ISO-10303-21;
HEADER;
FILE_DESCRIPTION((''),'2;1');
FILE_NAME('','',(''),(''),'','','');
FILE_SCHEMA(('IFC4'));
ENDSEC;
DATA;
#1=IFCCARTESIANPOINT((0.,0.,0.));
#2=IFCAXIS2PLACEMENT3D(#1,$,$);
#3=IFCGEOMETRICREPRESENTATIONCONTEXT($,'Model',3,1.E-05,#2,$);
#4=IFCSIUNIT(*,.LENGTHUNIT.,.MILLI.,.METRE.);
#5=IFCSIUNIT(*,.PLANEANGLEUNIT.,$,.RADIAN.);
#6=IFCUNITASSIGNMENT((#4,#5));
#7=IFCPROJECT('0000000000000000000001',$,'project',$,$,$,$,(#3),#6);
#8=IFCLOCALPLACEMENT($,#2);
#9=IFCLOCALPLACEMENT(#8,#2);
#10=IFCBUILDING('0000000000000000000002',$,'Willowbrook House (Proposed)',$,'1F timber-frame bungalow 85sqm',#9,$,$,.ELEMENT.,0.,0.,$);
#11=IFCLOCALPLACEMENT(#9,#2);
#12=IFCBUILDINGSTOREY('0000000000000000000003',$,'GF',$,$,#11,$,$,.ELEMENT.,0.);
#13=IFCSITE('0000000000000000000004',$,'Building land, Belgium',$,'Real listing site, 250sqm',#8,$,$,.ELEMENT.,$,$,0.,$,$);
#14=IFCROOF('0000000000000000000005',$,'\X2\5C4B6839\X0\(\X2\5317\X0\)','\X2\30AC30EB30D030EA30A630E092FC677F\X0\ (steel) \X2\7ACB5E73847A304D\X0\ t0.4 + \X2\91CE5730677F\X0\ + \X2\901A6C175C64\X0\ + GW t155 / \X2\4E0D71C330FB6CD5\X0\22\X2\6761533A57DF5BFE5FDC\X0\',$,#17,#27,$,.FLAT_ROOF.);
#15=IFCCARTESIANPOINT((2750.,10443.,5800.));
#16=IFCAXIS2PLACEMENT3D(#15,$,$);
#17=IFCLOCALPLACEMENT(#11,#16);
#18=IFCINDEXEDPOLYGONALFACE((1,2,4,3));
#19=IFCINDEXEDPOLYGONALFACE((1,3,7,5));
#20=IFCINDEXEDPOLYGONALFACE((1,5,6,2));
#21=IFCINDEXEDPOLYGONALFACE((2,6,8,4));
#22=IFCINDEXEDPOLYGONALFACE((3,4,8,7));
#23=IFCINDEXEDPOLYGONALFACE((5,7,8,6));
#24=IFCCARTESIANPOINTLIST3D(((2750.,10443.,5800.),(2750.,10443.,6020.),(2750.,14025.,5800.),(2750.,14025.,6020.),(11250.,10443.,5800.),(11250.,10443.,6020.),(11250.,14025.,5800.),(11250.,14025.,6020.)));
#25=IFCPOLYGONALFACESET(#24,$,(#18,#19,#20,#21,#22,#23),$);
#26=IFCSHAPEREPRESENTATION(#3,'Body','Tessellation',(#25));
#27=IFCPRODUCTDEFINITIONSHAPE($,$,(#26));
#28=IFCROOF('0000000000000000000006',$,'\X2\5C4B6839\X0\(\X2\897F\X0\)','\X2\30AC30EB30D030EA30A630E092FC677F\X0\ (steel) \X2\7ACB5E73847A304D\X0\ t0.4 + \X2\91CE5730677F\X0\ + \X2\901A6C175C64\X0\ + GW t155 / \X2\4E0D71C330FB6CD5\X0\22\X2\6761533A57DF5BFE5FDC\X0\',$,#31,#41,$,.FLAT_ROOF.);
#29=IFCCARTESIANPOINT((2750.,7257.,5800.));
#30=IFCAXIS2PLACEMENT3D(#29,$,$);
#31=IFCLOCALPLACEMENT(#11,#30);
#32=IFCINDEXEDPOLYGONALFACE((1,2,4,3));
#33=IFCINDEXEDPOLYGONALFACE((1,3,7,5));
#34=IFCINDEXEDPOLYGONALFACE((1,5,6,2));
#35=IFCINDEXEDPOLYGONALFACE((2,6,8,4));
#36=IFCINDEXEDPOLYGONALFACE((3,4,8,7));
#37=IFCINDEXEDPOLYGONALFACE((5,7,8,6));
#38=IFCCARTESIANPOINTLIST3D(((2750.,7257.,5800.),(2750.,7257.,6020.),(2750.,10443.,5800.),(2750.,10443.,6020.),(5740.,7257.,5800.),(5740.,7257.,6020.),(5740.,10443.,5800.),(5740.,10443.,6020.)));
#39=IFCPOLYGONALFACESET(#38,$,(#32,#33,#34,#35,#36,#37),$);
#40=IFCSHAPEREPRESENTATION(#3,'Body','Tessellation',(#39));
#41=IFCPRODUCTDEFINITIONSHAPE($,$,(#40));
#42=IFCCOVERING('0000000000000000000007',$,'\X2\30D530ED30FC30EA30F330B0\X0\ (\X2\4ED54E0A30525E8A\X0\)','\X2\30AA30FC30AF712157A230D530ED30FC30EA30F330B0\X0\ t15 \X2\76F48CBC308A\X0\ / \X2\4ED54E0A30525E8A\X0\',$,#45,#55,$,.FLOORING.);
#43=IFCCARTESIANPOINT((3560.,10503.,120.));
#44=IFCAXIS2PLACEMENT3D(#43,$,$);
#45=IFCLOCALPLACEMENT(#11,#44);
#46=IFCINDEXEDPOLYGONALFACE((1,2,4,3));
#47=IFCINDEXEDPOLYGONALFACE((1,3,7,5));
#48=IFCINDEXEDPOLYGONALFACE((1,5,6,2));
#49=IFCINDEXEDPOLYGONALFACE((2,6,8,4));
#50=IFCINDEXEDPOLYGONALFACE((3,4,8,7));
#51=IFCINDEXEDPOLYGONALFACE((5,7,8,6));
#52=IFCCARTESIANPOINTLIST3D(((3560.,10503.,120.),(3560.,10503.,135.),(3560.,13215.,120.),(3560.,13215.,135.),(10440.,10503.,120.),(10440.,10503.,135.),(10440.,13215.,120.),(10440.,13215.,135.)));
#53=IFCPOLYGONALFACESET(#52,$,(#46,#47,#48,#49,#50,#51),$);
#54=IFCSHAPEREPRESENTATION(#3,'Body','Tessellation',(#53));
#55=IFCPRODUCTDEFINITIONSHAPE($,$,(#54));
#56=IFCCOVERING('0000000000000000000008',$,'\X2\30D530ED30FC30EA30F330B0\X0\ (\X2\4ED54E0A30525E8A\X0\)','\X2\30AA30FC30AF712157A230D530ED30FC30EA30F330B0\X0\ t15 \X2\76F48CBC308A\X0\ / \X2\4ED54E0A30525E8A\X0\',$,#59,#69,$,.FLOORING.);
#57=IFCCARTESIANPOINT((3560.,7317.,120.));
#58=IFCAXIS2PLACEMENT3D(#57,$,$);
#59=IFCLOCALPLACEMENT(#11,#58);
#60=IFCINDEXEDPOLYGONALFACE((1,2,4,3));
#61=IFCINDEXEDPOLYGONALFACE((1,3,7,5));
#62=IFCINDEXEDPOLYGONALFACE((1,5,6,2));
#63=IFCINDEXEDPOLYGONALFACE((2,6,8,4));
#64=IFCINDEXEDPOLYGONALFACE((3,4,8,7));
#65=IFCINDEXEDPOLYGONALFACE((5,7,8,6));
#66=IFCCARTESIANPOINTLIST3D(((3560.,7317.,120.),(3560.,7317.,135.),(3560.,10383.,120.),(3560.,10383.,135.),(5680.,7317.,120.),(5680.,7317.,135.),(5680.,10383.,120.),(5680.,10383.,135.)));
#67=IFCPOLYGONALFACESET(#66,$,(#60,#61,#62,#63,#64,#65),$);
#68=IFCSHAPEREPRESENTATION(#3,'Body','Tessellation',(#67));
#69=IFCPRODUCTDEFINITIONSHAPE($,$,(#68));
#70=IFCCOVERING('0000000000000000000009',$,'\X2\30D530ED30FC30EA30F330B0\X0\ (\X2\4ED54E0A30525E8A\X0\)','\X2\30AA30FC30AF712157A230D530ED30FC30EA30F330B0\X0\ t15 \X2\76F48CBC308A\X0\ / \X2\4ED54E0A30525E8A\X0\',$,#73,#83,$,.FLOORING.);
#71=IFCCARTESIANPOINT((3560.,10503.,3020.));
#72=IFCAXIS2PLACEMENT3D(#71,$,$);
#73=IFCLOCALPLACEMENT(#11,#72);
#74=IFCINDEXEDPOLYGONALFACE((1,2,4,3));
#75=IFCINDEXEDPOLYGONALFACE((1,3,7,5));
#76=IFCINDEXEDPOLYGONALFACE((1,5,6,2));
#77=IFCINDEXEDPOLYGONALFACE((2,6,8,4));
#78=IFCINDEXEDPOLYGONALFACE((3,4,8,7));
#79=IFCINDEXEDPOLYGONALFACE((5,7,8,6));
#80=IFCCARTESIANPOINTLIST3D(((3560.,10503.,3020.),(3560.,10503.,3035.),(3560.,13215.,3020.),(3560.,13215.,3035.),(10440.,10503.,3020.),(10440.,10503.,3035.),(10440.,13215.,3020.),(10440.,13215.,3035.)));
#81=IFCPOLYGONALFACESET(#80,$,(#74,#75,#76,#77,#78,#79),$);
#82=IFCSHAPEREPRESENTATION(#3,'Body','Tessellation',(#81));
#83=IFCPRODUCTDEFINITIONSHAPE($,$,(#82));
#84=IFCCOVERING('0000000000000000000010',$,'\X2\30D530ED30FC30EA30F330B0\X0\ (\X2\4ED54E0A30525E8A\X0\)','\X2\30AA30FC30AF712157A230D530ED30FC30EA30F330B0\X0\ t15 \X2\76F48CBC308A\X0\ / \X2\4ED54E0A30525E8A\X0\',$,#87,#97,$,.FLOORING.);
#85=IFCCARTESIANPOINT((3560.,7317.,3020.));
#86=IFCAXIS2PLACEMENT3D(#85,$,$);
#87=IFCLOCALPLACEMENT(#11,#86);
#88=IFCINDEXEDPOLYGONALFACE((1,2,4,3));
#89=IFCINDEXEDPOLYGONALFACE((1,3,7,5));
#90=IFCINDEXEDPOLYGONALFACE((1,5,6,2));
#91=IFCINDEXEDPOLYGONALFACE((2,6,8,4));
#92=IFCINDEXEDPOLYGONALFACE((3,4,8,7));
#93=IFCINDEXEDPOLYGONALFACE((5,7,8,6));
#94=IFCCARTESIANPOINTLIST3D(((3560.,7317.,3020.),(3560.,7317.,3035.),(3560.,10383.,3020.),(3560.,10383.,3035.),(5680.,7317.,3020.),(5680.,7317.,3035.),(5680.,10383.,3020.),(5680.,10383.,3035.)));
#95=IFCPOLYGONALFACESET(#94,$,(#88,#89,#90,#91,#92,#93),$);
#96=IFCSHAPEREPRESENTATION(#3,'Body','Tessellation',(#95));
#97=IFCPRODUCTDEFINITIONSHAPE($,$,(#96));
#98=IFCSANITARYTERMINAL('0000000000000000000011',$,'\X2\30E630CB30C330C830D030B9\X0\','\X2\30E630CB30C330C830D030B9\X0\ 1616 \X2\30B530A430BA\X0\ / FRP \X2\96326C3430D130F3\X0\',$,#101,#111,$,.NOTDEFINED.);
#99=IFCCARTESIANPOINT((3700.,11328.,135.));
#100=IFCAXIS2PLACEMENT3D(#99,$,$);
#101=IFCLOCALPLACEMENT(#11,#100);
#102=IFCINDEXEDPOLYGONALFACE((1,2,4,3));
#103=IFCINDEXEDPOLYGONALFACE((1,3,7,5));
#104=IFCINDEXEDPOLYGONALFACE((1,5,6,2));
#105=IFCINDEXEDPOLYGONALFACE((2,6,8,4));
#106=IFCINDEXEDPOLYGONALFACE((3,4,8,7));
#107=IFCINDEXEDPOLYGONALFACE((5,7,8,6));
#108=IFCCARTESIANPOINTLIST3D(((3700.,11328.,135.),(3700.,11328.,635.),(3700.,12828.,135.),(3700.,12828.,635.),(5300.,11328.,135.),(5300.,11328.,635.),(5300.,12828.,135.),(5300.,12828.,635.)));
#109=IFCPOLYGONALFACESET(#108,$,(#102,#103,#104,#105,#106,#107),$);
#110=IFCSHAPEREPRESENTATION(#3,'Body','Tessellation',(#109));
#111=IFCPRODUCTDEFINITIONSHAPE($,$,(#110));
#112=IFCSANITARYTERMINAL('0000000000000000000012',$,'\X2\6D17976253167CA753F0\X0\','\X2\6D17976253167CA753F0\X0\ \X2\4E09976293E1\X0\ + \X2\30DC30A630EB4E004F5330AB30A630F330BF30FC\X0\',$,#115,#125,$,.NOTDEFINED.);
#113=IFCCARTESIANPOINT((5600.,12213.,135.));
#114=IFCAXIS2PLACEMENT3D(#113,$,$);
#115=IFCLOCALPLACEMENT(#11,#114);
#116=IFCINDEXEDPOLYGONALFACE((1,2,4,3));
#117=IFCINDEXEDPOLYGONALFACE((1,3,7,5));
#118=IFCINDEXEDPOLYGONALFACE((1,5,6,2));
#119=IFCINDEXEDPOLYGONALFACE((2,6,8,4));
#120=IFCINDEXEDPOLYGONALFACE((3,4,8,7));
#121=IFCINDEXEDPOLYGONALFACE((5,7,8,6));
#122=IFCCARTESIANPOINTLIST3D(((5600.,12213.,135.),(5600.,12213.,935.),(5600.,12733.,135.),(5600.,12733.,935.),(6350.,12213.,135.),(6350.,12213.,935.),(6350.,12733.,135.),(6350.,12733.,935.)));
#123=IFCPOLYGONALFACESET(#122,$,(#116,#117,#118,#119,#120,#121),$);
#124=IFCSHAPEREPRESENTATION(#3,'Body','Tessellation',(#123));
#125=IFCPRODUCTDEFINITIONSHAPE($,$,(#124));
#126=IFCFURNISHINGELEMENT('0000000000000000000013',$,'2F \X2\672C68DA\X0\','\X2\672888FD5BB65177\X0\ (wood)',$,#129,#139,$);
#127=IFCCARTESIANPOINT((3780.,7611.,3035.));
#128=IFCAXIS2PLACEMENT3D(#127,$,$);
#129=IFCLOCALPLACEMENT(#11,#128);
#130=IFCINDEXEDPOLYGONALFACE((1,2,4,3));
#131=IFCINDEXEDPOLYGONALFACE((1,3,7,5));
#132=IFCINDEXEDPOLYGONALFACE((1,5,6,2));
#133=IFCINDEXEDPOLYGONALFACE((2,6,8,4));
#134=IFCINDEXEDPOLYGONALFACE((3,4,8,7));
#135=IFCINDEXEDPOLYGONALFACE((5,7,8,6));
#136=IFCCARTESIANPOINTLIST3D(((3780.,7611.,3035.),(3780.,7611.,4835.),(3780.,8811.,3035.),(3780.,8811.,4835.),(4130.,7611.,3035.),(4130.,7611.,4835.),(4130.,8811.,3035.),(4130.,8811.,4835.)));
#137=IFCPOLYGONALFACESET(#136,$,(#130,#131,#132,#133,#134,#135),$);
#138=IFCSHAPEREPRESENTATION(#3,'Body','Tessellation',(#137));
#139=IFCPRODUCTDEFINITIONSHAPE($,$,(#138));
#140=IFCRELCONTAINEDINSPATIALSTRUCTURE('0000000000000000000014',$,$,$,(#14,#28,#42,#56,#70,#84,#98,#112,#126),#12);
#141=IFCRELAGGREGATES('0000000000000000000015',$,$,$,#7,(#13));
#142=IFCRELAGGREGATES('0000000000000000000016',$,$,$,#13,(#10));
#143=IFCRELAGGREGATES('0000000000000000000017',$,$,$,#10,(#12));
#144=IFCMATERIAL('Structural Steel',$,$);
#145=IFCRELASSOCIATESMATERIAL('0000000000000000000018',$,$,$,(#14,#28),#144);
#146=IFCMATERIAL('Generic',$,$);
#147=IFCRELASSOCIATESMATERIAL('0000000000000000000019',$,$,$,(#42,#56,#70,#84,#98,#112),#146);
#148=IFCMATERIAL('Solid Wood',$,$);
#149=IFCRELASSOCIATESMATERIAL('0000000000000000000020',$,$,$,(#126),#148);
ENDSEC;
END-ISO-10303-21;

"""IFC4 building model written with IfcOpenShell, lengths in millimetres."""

from ifc_helpers import new_model, si_unit, frame, frame_2d, origin, place, context, project, spatial, rectangle, extrude, material, element, save


model = new_model("IFC4")

# Units and contexts
model_context = context("Model", 3, precision=1e-05, world=origin())
ifc_project = project(units=[si_unit("LENGTHUNIT", "METRE", prefix="MILLI"), si_unit("PLANEANGLEUNIT", "RADIAN")], contexts=[model_context])

# Site, building, storey
site_placement = place(None, origin())
site = spatial("IfcSite", under=ifc_project, at=site_placement, Name="Building land, Belgium", ObjectType="Real listing site, 250sqm", CompositionType="ELEMENT", RefElevation=0.0)
building_placement = place(site_placement, origin())
building = spatial("IfcBuilding", under=site, at=building_placement, Name="Willowbrook House (Proposed)", ObjectType="1F timber-frame bungalow 85sqm", CompositionType="ELEMENT", ElevationOfRefHeight=0.0, ElevationOfTerrain=0.0)
storey_placement = place(building_placement, origin())
storey = spatial("IfcBuildingStorey", under=building, at=storey_placement, Name="GF", CompositionType="ELEMENT", Elevation=0.0)

# Shared definitions
ifc_material_1 = material(Name="Solid Wood")

# Roofs
ifc_material_2 = material(Name="Structural Steel")
for number, where, name in (
    (1, (2750.0, 10443.0, 5800.0), "屋根(北)"),
):
    element("IfcRoof", number, at=place(storey_placement, frame(where)), inside=storey, material=ifc_material_2, Name=name, Description="ガルバリウム鋼板 (steel) 立平葺き t0.4 + 野地板 + 通気層 + GW t155 / 不燃・法22条区域対応", PredefinedType="FLAT_ROOF", context=model_context, shape_type="SweptSolid", body=[
        extrude(rectangle(XDim=8500.0, YDim=3582.0, at=frame_2d((4250.0, 1791.0))), frame((2750.0, 10443.0, 5800.0)), (0.0, 0.0, 1.0), 220.0),
    ])
roof_placement = place(storey_placement, frame((2750.0, 7257.0, 5800.0)))
element("IfcRoof", 2, at=roof_placement, inside=storey, material=ifc_material_2, Name="屋根(西)", Description="ガルバリウム鋼板 (steel) 立平葺き t0.4 + 野地板 + 通気層 + GW t155 / 不燃・法22条区域対応", PredefinedType="FLAT_ROOF", context=model_context, shape_type="SweptSolid", body=[
    extrude(rectangle(XDim=2990.0, YDim=3186.0, at=frame_2d((1495.0, 1593.0))), frame((2750.0, 7257.0, 5800.0)), (0.0, 0.0, 1.0), 220.0),
])

# Coverings
ifc_material_3 = material(Name="Generic")
covering_1_placement = place(storey_placement, frame((3560.0, 10503.0, 120.0)))
element("IfcCovering", 3, at=covering_1_placement, inside=storey, material=ifc_material_3, Name="フローリング (仕上げ床)", Description="オーク無垢フローリング t15 直貼り / 仕上げ床", PredefinedType="FLOORING", context=model_context, shape_type="SweptSolid", body=[
    extrude(rectangle(XDim=6880.0, YDim=2712.0, at=frame_2d((3440.0, 1356.0))), frame((3560.0, 10503.0, 120.0)), (0.0, 0.0, 1.0), 15.0),
])
covering_2_placement = place(storey_placement, frame((3560.0, 7317.0, 120.0)))
element("IfcCovering", 4, at=covering_2_placement, inside=storey, material=ifc_material_3, Name="フローリング (仕上げ床)", Description="オーク無垢フローリング t15 直貼り / 仕上げ床", PredefinedType="FLOORING", context=model_context, shape_type="SweptSolid", body=[
    extrude(rectangle(XDim=2120.0, YDim=3066.0, at=frame_2d((1060.0, 1533.0))), frame((3560.0, 7317.0, 120.0)), (0.0, 0.0, 1.0), 15.0),
])
covering_3_placement = place(storey_placement, frame((3560.0, 10503.0, 3020.0)))
element("IfcCovering", 5, at=covering_3_placement, inside=storey, material=ifc_material_3, Name="フローリング (仕上げ床)", Description="オーク無垢フローリング t15 直貼り / 仕上げ床", PredefinedType="FLOORING", context=model_context, shape_type="SweptSolid", body=[
    extrude(rectangle(XDim=6880.0, YDim=2712.0, at=frame_2d((3440.0, 1356.0))), frame((3560.0, 10503.0, 3020.0)), (0.0, 0.0, 1.0), 15.0),
])
covering_4_placement = place(storey_placement, frame((3560.0, 7317.0, 3020.0)))
element("IfcCovering", 6, at=covering_4_placement, inside=storey, material=ifc_material_3, Name="フローリング (仕上げ床)", Description="オーク無垢フローリング t15 直貼り / 仕上げ床", PredefinedType="FLOORING", context=model_context, shape_type="SweptSolid", body=[
    extrude(rectangle(XDim=2120.0, YDim=3066.0, at=frame_2d((1060.0, 1533.0))), frame((3560.0, 7317.0, 3020.0)), (0.0, 0.0, 1.0), 15.0),
])

# Sanitary terminals
sanitary_terminal_1_placement = place(storey_placement, frame((3700.0, 11328.0, 135.0)))
element("IfcSanitaryTerminal", 7, at=sanitary_terminal_1_placement, inside=storey, material=ifc_material_3, Name="ユニットバス", Description="ユニットバス 1616 サイズ / FRP 防水パン", PredefinedType="NOTDEFINED", context=model_context, shape_type="SweptSolid", body=[
    extrude(rectangle(XDim=1600.0, YDim=1500.0, at=frame_2d((800.0, 750.0))), frame((3700.0, 11328.0, 135.0)), (0.0, 0.0, 1.0), 500.0),
])
sanitary_terminal_2_placement = place(storey_placement, frame((5600.0, 12213.0, 135.0)))
element("IfcSanitaryTerminal", 8, at=sanitary_terminal_2_placement, inside=storey, material=ifc_material_3, Name="洗面化粧台", Description="洗面化粧台 三面鏡 + ボウル一体カウンター", PredefinedType="NOTDEFINED", context=model_context, shape_type="SweptSolid", body=[
    extrude(rectangle(XDim=750.0, YDim=520.0, at=frame_2d((375.0, 260.0))), frame((5600.0, 12213.0, 135.0)), (0.0, 0.0, 1.0), 800.0),
])

# Furnishing element
furnishing_placement = place(storey_placement, frame((3780.0, 7611.0, 3035.0)))
element("IfcFurnishingElement", 9, at=furnishing_placement, inside=storey, material=ifc_material_1, Name="2F 本棚", Description="木製家具 (wood)", context=model_context, shape_type="SweptSolid", body=[
    extrude(rectangle(XDim=350.0, YDim=1200.0, at=frame_2d((175.0, 600.0))), frame((3780.0, 7611.0, 3035.0)), (0.0, 0.0, 1.0), 1800.0),
])

save(model, "model.ifc")
